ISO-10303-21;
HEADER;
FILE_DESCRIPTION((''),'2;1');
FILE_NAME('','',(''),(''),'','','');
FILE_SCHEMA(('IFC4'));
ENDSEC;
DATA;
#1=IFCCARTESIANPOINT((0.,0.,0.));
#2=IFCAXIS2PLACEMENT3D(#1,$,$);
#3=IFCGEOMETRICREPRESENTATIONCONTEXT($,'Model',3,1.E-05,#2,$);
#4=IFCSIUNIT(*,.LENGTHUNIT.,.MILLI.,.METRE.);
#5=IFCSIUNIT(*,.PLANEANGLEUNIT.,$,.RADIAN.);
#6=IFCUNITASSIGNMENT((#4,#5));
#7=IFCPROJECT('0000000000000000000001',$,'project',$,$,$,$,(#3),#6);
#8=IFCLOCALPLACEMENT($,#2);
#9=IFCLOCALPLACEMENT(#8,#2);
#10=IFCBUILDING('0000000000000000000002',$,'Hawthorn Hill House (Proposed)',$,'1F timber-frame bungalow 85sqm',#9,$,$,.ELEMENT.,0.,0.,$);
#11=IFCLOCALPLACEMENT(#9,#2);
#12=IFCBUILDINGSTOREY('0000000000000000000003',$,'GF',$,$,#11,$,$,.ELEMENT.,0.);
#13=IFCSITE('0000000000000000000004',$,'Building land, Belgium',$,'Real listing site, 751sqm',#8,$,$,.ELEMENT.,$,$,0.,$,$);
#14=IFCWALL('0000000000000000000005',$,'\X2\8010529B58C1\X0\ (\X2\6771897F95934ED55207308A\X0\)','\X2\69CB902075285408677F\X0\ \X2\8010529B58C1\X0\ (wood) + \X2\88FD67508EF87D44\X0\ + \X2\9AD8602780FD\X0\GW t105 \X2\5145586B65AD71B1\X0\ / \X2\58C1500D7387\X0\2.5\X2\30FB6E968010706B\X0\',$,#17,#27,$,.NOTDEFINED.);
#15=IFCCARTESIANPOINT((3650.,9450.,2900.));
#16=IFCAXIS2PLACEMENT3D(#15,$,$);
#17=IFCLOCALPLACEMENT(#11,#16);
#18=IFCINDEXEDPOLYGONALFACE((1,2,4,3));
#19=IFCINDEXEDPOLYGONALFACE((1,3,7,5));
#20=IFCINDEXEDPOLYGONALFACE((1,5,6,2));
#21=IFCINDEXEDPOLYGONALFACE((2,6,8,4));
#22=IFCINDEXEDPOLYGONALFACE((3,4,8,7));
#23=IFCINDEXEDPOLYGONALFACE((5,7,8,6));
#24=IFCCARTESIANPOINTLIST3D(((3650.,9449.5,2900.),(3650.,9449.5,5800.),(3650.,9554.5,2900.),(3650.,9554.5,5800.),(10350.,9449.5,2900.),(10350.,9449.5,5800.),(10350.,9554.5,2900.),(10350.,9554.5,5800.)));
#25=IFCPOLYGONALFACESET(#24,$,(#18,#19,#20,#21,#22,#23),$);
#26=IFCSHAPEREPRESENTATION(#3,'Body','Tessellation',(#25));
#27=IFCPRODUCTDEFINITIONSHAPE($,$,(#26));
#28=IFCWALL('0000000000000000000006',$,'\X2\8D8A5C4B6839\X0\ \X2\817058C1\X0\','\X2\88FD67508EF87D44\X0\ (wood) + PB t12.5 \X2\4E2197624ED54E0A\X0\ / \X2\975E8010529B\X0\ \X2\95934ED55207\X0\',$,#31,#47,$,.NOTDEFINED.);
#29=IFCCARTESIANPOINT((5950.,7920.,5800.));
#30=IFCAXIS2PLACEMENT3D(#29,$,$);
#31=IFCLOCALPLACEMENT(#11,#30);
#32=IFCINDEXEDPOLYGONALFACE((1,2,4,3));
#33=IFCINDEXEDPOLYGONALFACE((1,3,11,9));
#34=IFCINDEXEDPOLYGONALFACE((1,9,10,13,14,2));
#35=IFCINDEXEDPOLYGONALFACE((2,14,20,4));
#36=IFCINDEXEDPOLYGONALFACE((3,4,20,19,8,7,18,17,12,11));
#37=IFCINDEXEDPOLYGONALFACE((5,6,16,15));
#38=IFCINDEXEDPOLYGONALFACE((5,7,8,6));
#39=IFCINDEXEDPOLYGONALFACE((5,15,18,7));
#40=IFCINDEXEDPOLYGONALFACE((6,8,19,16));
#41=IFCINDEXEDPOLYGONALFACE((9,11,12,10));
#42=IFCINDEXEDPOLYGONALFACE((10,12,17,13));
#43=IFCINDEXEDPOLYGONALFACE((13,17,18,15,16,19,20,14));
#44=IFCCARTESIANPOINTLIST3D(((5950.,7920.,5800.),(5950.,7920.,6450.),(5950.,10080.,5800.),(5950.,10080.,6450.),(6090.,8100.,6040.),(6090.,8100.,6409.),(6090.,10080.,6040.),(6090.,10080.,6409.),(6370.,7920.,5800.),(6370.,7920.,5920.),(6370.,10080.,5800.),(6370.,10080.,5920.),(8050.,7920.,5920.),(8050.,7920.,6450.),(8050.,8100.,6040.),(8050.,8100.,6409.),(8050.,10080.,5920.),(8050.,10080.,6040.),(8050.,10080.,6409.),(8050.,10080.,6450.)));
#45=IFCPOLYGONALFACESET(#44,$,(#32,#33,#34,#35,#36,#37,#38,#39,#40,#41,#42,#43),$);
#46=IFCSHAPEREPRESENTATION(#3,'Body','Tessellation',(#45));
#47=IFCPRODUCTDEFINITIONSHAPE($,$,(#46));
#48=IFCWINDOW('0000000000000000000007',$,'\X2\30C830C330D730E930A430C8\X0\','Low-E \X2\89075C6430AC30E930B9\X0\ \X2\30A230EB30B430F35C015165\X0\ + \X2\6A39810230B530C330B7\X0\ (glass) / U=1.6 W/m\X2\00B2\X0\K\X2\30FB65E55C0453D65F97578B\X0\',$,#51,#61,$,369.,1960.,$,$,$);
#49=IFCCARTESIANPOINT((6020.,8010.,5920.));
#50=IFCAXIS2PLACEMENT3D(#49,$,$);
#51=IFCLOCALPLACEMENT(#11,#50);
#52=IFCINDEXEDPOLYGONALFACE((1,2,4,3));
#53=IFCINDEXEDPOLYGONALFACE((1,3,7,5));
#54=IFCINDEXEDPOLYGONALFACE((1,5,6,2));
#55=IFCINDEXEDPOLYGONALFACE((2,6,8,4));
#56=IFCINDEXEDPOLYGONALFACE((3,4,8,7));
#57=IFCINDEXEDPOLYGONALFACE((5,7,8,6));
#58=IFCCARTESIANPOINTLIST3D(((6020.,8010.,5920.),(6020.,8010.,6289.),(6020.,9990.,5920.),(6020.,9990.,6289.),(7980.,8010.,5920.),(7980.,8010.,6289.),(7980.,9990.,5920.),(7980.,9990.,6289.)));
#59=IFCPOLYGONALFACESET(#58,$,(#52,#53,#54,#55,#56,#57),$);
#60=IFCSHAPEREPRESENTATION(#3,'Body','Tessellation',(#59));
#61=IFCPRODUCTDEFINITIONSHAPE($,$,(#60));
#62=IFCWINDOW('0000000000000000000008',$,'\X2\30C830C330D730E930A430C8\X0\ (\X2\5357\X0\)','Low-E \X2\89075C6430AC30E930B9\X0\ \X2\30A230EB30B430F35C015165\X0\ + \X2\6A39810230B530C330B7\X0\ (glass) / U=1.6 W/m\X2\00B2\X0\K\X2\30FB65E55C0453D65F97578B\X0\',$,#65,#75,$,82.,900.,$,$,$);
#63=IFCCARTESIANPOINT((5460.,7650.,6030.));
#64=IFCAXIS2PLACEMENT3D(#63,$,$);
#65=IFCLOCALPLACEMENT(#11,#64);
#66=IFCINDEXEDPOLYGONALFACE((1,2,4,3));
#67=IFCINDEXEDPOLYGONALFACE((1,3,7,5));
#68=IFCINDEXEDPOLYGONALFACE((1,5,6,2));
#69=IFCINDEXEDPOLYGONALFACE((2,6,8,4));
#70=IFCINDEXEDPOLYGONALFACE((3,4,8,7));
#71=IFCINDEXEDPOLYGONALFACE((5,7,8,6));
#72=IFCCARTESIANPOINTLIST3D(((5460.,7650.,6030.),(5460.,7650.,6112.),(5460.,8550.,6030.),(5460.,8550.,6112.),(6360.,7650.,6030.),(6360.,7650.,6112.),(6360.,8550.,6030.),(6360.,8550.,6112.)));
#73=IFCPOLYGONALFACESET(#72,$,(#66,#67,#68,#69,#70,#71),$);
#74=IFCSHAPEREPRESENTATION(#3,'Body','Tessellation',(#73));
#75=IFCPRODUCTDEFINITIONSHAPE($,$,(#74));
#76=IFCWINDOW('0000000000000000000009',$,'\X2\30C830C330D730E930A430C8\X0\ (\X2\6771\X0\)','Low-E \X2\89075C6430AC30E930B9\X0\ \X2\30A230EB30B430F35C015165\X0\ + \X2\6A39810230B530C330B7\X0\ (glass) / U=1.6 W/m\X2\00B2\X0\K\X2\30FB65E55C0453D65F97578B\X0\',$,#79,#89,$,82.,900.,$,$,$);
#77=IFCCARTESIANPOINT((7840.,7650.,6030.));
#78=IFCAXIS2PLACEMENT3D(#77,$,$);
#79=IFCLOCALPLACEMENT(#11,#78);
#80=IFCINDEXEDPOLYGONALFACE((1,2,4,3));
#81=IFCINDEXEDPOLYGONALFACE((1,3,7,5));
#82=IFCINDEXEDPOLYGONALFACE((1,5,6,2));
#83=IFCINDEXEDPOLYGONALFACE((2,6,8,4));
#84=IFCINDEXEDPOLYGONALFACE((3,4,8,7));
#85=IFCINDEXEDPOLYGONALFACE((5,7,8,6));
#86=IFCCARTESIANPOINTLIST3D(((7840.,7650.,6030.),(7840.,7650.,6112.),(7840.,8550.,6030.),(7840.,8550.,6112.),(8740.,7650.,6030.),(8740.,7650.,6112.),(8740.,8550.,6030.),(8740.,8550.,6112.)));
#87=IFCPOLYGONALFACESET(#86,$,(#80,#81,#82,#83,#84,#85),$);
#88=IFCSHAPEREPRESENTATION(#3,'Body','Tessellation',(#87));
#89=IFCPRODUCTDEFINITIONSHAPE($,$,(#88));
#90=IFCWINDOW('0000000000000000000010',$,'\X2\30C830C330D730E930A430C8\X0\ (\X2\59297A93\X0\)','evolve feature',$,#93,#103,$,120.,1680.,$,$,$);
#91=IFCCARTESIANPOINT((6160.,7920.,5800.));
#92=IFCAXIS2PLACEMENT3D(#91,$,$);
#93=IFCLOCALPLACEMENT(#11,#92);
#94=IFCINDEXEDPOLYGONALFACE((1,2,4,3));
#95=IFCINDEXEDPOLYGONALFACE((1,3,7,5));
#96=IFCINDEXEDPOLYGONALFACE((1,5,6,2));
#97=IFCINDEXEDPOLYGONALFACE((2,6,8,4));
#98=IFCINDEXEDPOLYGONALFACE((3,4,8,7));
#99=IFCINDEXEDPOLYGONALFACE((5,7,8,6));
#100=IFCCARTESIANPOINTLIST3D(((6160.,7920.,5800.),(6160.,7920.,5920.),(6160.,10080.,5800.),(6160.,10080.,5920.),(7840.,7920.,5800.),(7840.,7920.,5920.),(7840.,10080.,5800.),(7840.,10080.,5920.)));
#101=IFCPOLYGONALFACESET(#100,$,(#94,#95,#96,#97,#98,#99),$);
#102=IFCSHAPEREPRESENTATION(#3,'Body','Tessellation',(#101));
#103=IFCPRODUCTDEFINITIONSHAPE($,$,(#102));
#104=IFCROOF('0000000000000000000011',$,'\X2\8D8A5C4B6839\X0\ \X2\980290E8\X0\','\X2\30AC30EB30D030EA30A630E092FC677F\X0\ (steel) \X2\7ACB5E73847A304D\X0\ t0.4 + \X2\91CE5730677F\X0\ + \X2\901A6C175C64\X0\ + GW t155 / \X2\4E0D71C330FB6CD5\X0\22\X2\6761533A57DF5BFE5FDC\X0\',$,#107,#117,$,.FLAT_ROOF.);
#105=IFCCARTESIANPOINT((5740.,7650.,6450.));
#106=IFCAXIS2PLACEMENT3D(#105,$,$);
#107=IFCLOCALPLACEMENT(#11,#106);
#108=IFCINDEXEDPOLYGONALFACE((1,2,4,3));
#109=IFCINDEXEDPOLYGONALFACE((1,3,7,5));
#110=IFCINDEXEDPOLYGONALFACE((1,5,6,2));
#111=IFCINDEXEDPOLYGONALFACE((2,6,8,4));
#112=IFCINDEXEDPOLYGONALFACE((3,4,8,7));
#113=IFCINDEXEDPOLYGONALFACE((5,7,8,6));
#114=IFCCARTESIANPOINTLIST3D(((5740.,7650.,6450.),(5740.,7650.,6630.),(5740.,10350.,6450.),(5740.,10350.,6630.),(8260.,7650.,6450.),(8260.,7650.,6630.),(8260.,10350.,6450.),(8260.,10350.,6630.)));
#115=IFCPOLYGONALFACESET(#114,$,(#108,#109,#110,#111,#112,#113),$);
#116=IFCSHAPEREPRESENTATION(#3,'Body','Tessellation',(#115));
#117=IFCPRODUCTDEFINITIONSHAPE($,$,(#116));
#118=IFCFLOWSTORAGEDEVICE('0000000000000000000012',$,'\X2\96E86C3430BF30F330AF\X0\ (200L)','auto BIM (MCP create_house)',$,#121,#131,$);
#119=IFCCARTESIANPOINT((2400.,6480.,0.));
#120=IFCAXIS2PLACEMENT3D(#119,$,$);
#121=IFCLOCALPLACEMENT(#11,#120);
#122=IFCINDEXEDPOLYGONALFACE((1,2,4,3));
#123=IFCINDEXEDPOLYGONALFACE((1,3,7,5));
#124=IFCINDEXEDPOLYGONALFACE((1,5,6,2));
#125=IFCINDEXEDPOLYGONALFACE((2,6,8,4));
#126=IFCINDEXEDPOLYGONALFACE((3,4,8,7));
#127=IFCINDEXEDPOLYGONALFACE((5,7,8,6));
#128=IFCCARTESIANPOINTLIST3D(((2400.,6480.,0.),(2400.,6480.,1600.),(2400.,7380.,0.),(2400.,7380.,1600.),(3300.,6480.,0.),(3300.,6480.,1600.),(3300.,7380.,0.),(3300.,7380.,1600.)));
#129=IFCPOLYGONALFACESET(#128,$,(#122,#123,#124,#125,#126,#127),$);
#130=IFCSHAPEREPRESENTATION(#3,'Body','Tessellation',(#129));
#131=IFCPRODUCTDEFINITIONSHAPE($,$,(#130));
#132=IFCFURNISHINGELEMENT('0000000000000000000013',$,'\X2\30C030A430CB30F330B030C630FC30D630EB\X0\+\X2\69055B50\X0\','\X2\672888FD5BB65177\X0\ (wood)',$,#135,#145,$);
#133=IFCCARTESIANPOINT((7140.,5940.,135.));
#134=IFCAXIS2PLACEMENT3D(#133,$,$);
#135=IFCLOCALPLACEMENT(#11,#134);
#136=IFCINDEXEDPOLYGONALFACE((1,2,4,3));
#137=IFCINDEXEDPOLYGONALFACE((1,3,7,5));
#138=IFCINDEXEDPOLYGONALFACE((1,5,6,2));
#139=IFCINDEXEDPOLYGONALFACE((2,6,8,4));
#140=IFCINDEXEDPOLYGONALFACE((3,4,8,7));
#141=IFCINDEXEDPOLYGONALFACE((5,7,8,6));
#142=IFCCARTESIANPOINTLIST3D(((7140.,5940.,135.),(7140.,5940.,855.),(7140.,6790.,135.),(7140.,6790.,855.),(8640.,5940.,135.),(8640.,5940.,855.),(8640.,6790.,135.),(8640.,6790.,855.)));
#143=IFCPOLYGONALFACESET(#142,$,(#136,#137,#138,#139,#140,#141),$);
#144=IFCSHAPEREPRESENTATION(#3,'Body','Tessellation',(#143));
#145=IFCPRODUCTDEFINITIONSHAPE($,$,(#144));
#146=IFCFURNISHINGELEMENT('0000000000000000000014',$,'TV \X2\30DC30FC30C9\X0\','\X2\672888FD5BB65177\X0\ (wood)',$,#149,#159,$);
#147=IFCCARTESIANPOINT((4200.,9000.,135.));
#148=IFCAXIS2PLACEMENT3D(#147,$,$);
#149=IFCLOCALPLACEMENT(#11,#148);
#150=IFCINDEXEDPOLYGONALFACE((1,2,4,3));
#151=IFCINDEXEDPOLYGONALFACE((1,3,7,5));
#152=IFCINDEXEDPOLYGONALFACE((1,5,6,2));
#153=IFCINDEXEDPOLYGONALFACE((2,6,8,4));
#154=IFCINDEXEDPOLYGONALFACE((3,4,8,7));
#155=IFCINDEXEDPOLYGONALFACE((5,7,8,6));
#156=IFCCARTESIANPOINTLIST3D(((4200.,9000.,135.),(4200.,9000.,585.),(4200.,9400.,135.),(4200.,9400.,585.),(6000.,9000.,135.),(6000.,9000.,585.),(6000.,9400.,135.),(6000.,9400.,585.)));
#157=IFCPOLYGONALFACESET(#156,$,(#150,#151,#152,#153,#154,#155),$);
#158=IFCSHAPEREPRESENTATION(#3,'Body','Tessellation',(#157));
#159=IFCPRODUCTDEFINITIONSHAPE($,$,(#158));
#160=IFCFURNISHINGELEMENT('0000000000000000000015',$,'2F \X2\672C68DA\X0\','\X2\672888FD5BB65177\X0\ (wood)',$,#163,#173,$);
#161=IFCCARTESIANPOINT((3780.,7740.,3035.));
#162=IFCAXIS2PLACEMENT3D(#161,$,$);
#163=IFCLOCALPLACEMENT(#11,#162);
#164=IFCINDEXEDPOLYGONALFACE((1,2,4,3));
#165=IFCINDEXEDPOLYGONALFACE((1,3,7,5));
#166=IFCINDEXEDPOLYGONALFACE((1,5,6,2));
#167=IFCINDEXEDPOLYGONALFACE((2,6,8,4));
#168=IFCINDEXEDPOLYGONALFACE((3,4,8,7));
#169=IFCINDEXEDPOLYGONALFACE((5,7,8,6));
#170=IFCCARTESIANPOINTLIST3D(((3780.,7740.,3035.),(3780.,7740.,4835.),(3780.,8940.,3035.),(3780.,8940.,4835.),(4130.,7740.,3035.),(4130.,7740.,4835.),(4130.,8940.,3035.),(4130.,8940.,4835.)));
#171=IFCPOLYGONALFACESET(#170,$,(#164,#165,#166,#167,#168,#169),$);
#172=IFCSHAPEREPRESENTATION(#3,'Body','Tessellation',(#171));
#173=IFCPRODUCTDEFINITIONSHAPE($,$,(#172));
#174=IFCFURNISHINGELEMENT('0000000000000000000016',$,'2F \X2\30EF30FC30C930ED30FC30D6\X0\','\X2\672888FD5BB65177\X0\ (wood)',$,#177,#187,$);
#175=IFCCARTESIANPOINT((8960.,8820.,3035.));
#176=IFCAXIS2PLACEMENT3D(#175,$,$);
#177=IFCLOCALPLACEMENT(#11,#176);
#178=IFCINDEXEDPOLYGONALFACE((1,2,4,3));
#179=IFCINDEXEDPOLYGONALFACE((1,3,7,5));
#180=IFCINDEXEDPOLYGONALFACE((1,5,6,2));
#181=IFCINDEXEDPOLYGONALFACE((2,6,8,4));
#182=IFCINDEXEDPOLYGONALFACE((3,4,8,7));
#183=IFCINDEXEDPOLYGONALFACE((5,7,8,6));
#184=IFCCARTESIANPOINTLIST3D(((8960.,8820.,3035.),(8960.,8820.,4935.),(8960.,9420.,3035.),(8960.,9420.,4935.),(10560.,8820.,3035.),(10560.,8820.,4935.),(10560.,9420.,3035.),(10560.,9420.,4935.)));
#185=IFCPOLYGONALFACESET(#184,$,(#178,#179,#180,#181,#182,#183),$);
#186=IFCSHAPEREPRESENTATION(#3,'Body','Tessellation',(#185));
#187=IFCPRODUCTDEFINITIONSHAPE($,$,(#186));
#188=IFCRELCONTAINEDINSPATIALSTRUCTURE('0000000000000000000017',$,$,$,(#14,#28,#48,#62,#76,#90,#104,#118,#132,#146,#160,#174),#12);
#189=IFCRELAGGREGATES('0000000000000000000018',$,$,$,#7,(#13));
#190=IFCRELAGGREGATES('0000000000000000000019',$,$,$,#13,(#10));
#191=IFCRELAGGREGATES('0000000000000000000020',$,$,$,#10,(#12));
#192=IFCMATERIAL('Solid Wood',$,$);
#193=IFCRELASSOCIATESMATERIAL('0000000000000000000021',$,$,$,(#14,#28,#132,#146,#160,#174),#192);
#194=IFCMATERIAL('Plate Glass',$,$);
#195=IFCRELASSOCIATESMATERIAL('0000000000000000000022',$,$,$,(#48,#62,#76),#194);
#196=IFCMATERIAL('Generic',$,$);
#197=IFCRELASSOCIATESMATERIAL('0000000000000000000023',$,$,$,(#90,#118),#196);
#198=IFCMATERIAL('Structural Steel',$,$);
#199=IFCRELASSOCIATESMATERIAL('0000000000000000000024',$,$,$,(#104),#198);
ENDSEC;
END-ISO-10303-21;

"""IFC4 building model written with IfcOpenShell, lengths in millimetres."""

from ifc_helpers import new_model, si_unit, frame, frame_2d, origin, place, context, project, spatial, rectangle, extrude, material, element, fill, save


model = new_model("IFC4")

# Units and contexts
model_context = context("Model", 3, precision=1e-05, world=origin())
ifc_project = project(units=[si_unit("LENGTHUNIT", "METRE", prefix="MILLI"), si_unit("PLANEANGLEUNIT", "RADIAN")], contexts=[model_context])

# Site, building, storey
site_placement = place(None, origin())
site = spatial("IfcSite", under=ifc_project, at=site_placement, Name="Building land, Belgium", ObjectType="Real listing site, 751sqm", CompositionType="ELEMENT", RefElevation=0.0)
building_placement = place(site_placement, origin())
building = spatial("IfcBuilding", under=site, at=building_placement, Name="Hawthorn Hill House (Proposed)", ObjectType="1F timber-frame bungalow 85sqm", CompositionType="ELEMENT", ElevationOfRefHeight=0.0, ElevationOfTerrain=0.0)
storey_placement = place(building_placement, origin())
storey = spatial("IfcBuildingStorey", under=building, at=storey_placement, Name="GF", CompositionType="ELEMENT", Elevation=0.0)

# Wall
ifc_material_1 = material(Name="Solid Wood")
wall_1_placement = place(storey_placement, frame((3650.0, 9450.0, 2900.0)))
element("IfcWall", 1, at=wall_1_placement, inside=storey, material=ifc_material_1, Name="耐力壁 (東西間仕切り)", Description="構造用合板 耐力壁 (wood) + 製材軸組 + 高性能GW t105 充填断熱 / 壁倍率2.5・準耐火", PredefinedType="NOTDEFINED", context=model_context, shape_type="SweptSolid", body=[
    extrude(rectangle(XDim=6700.0, YDim=105.0, at=frame_2d((3350.0, 52.0))), frame((3650.0, 9450.0, 2900.0)), (0.0, 0.0, 1.0), 2900.0),
])

# Wall, openings, windows
wall_2_placement = place(storey_placement, frame((5950.0, 7920.0, 5800.0)))
wall_2 = element("IfcWall", 2, at=wall_2_placement, inside=storey, material=ifc_material_1, Name="越屋根 腰壁", Description="製材軸組 (wood) + PB t12.5 両面仕上 / 非耐力 間仕切", PredefinedType="NOTDEFINED", context=model_context, shape_type="SweptSolid", body=[
    extrude(rectangle(XDim=2100.0, YDim=2160.0, at=frame_2d((1050.0, 1080.0))), frame((5950.0, 7920.0, 5800.0)), (0.0, 0.0, 1.0), 650.0),
])
opening_1_placement = place(storey_placement, frame((6020.0, 8010.0, 5920.0)))
opening_1 = element("IfcOpeningElement", 3, at=opening_1_placement, cuts=wall_2, PredefinedType="NOTDEFINED", context=model_context, shape_type="SweptSolid", body=[
    extrude(rectangle(XDim=1960.0, YDim=1980.0, at=frame_2d((980.0, 990.0))), frame((6020.0, 8010.0, 5920.0)), (0.0, 0.0, 1.0), 369.0),
])
opening_2_placement = place(storey_placement, frame((5460.0, 7650.0, 6030.0)))
opening_2 = element("IfcOpeningElement", 4, at=opening_2_placement, cuts=wall_2, PredefinedType="NOTDEFINED", context=model_context, shape_type="SweptSolid", body=[
    extrude(rectangle(XDim=900.0, YDim=900.0, at=frame_2d((450.0, 450.0))), frame((5460.0, 7650.0, 6030.0)), (0.0, 0.0, 1.0), 82.0),
])
opening_3_placement = place(storey_placement, frame((7840.0, 7650.0, 6030.0)))
opening_3 = element("IfcOpeningElement", 5, at=opening_3_placement, cuts=wall_2, PredefinedType="NOTDEFINED", context=model_context, shape_type="SweptSolid", body=[
    extrude(rectangle(XDim=900.0, YDim=900.0, at=frame_2d((450.0, 450.0))), frame((7840.0, 7650.0, 6030.0)), (0.0, 0.0, 1.0), 82.0),
])
opening_4_placement = place(storey_placement, frame((6160.0, 7920.0, 5800.0)))
opening_4 = element("IfcOpeningElement", 6, at=opening_4_placement, cuts=wall_2, PredefinedType="NOTDEFINED", context=model_context, shape_type="SweptSolid", body=[
    extrude(rectangle(XDim=1680.0, YDim=2160.0, at=frame_2d((840.0, 1080.0))), frame((6160.0, 7920.0, 5800.0)), (0.0, 0.0, 1.0), 120.0),
])
ifc_material_2 = material(Name="Plate Glass")
window_1_placement = place(storey_placement, frame((6020.0, 8010.0, 5920.0)))
window_1 = element("IfcWindow", 7, at=window_1_placement, inside=storey, material=ifc_material_2, Name="トップライト", Description="Low-E 複層ガラス アルゴン封入 + 樹脂サッシ (glass) / U=1.6 W/m²K・日射取得型", OverallHeight=369.0, OverallWidth=1960.0, context=model_context, shape_type="SweptSolid", body=[
    extrude(rectangle(XDim=1960.0, YDim=1980.0, at=frame_2d((980.0, 990.0))), frame((6020.0, 8010.0, 5920.0)), (0.0, 0.0, 1.0), 369.0),
])
fill(opening_1, window_1)
window_2_placement = place(storey_placement, frame((5460.0, 7650.0, 6030.0)))
window_2 = element("IfcWindow", 8, at=window_2_placement, inside=storey, material=ifc_material_2, Name="トップライト (南)", Description="Low-E 複層ガラス アルゴン封入 + 樹脂サッシ (glass) / U=1.6 W/m²K・日射取得型", OverallHeight=82.0, OverallWidth=900.0, context=model_context, shape_type="SweptSolid", body=[
    extrude(rectangle(XDim=900.0, YDim=900.0, at=frame_2d((450.0, 450.0))), frame((5460.0, 7650.0, 6030.0)), (0.0, 0.0, 1.0), 82.0),
])
fill(opening_2, window_2)
window_3_placement = place(storey_placement, frame((7840.0, 7650.0, 6030.0)))
window_3 = element("IfcWindow", 9, at=window_3_placement, inside=storey, material=ifc_material_2, Name="トップライト (東)", Description="Low-E 複層ガラス アルゴン封入 + 樹脂サッシ (glass) / U=1.6 W/m²K・日射取得型", OverallHeight=82.0, OverallWidth=900.0, context=model_context, shape_type="SweptSolid", body=[
    extrude(rectangle(XDim=900.0, YDim=900.0, at=frame_2d((450.0, 450.0))), frame((7840.0, 7650.0, 6030.0)), (0.0, 0.0, 1.0), 82.0),
])
fill(opening_3, window_3)
ifc_material_3 = material(Name="Generic")
window_4_placement = place(storey_placement, frame((6160.0, 7920.0, 5800.0)))
window_4 = element("IfcWindow", 10, at=window_4_placement, inside=storey, material=ifc_material_3, Name="トップライト (天窓)", Description="evolve feature", OverallHeight=120.0, OverallWidth=1680.0, context=model_context, shape_type="SweptSolid", body=[
    extrude(rectangle(XDim=1680.0, YDim=2160.0, at=frame_2d((840.0, 1080.0))), frame((6160.0, 7920.0, 5800.0)), (0.0, 0.0, 1.0), 120.0),
])
fill(opening_4, window_4)

# Roof
ifc_material_4 = material(Name="Structural Steel")
roof_placement = place(storey_placement, frame((5740.0, 7650.0, 6450.0)))
element("IfcRoof", 11, at=roof_placement, inside=storey, material=ifc_material_4, Name="越屋根 頂部", Description="ガルバリウム鋼板 (steel) 立平葺き t0.4 + 野地板 + 通気層 + GW t155 / 不燃・法22条区域対応", PredefinedType="FLAT_ROOF", context=model_context, shape_type="SweptSolid", body=[
    extrude(rectangle(XDim=2520.0, YDim=2700.0, at=frame_2d((1260.0, 1350.0))), frame((5740.0, 7650.0, 6450.0)), (0.0, 0.0, 1.0), 180.0),
])

# Flow storage device
flow_storage_device_placement = place(storey_placement, frame((2400.0, 6480.0, 0.0)))
element("IfcFlowStorageDevice", 12, at=flow_storage_device_placement, inside=storey, material=ifc_material_3, Name="雨水タンク (200L)", Description="auto BIM (MCP create_house)", context=model_context, shape_type="SweptSolid", body=[
    extrude(rectangle(XDim=900.0, YDim=900.0, at=frame_2d((450.0, 450.0))), frame((2400.0, 6480.0, 0.0)), (0.0, 0.0, 1.0), 1600.0),
])

# Furnishing elements
furnishing_1_placement = place(storey_placement, frame((7140.0, 5940.0, 135.0)))
element("IfcFurnishingElement", 13, at=furnishing_1_placement, inside=storey, material=ifc_material_1, Name="ダイニングテーブル+椅子", Description="木製家具 (wood)", context=model_context, shape_type="SweptSolid", body=[
    extrude(rectangle(XDim=1500.0, YDim=850.0, at=frame_2d((750.0, 425.0))), frame((7140.0, 5940.0, 135.0)), (0.0, 0.0, 1.0), 720.0),
])
furnishing_2_placement = place(storey_placement, frame((4200.0, 9000.0, 135.0)))
element("IfcFurnishingElement", 14, at=furnishing_2_placement, inside=storey, material=ifc_material_1, Name="TV ボード", Description="木製家具 (wood)", context=model_context, shape_type="SweptSolid", body=[
    extrude(rectangle(XDim=1800.0, YDim=400.0, at=frame_2d((900.0, 200.0))), frame((4200.0, 9000.0, 135.0)), (0.0, 0.0, 1.0), 450.0),
])
furnishing_3_placement = place(storey_placement, frame((3780.0, 7740.0, 3035.0)))
element("IfcFurnishingElement", 15, at=furnishing_3_placement, inside=storey, material=ifc_material_1, Name="2F 本棚", Description="木製家具 (wood)", context=model_context, shape_type="SweptSolid", body=[
    extrude(rectangle(XDim=350.0, YDim=1200.0, at=frame_2d((175.0, 600.0))), frame((3780.0, 7740.0, 3035.0)), (0.0, 0.0, 1.0), 1800.0),
])
furnishing_4_placement = place(storey_placement, frame((8960.0, 8820.0, 3035.0)))
element("IfcFurnishingElement", 16, at=furnishing_4_placement, inside=storey, material=ifc_material_1, Name="2F ワードローブ", Description="木製家具 (wood)", context=model_context, shape_type="SweptSolid", body=[
    extrude(rectangle(XDim=1600.0, YDim=600.0, at=frame_2d((800.0, 300.0))), frame((8960.0, 8820.0, 3035.0)), (0.0, 0.0, 1.0), 1900.0),
])

save(model, "model.ifc")
